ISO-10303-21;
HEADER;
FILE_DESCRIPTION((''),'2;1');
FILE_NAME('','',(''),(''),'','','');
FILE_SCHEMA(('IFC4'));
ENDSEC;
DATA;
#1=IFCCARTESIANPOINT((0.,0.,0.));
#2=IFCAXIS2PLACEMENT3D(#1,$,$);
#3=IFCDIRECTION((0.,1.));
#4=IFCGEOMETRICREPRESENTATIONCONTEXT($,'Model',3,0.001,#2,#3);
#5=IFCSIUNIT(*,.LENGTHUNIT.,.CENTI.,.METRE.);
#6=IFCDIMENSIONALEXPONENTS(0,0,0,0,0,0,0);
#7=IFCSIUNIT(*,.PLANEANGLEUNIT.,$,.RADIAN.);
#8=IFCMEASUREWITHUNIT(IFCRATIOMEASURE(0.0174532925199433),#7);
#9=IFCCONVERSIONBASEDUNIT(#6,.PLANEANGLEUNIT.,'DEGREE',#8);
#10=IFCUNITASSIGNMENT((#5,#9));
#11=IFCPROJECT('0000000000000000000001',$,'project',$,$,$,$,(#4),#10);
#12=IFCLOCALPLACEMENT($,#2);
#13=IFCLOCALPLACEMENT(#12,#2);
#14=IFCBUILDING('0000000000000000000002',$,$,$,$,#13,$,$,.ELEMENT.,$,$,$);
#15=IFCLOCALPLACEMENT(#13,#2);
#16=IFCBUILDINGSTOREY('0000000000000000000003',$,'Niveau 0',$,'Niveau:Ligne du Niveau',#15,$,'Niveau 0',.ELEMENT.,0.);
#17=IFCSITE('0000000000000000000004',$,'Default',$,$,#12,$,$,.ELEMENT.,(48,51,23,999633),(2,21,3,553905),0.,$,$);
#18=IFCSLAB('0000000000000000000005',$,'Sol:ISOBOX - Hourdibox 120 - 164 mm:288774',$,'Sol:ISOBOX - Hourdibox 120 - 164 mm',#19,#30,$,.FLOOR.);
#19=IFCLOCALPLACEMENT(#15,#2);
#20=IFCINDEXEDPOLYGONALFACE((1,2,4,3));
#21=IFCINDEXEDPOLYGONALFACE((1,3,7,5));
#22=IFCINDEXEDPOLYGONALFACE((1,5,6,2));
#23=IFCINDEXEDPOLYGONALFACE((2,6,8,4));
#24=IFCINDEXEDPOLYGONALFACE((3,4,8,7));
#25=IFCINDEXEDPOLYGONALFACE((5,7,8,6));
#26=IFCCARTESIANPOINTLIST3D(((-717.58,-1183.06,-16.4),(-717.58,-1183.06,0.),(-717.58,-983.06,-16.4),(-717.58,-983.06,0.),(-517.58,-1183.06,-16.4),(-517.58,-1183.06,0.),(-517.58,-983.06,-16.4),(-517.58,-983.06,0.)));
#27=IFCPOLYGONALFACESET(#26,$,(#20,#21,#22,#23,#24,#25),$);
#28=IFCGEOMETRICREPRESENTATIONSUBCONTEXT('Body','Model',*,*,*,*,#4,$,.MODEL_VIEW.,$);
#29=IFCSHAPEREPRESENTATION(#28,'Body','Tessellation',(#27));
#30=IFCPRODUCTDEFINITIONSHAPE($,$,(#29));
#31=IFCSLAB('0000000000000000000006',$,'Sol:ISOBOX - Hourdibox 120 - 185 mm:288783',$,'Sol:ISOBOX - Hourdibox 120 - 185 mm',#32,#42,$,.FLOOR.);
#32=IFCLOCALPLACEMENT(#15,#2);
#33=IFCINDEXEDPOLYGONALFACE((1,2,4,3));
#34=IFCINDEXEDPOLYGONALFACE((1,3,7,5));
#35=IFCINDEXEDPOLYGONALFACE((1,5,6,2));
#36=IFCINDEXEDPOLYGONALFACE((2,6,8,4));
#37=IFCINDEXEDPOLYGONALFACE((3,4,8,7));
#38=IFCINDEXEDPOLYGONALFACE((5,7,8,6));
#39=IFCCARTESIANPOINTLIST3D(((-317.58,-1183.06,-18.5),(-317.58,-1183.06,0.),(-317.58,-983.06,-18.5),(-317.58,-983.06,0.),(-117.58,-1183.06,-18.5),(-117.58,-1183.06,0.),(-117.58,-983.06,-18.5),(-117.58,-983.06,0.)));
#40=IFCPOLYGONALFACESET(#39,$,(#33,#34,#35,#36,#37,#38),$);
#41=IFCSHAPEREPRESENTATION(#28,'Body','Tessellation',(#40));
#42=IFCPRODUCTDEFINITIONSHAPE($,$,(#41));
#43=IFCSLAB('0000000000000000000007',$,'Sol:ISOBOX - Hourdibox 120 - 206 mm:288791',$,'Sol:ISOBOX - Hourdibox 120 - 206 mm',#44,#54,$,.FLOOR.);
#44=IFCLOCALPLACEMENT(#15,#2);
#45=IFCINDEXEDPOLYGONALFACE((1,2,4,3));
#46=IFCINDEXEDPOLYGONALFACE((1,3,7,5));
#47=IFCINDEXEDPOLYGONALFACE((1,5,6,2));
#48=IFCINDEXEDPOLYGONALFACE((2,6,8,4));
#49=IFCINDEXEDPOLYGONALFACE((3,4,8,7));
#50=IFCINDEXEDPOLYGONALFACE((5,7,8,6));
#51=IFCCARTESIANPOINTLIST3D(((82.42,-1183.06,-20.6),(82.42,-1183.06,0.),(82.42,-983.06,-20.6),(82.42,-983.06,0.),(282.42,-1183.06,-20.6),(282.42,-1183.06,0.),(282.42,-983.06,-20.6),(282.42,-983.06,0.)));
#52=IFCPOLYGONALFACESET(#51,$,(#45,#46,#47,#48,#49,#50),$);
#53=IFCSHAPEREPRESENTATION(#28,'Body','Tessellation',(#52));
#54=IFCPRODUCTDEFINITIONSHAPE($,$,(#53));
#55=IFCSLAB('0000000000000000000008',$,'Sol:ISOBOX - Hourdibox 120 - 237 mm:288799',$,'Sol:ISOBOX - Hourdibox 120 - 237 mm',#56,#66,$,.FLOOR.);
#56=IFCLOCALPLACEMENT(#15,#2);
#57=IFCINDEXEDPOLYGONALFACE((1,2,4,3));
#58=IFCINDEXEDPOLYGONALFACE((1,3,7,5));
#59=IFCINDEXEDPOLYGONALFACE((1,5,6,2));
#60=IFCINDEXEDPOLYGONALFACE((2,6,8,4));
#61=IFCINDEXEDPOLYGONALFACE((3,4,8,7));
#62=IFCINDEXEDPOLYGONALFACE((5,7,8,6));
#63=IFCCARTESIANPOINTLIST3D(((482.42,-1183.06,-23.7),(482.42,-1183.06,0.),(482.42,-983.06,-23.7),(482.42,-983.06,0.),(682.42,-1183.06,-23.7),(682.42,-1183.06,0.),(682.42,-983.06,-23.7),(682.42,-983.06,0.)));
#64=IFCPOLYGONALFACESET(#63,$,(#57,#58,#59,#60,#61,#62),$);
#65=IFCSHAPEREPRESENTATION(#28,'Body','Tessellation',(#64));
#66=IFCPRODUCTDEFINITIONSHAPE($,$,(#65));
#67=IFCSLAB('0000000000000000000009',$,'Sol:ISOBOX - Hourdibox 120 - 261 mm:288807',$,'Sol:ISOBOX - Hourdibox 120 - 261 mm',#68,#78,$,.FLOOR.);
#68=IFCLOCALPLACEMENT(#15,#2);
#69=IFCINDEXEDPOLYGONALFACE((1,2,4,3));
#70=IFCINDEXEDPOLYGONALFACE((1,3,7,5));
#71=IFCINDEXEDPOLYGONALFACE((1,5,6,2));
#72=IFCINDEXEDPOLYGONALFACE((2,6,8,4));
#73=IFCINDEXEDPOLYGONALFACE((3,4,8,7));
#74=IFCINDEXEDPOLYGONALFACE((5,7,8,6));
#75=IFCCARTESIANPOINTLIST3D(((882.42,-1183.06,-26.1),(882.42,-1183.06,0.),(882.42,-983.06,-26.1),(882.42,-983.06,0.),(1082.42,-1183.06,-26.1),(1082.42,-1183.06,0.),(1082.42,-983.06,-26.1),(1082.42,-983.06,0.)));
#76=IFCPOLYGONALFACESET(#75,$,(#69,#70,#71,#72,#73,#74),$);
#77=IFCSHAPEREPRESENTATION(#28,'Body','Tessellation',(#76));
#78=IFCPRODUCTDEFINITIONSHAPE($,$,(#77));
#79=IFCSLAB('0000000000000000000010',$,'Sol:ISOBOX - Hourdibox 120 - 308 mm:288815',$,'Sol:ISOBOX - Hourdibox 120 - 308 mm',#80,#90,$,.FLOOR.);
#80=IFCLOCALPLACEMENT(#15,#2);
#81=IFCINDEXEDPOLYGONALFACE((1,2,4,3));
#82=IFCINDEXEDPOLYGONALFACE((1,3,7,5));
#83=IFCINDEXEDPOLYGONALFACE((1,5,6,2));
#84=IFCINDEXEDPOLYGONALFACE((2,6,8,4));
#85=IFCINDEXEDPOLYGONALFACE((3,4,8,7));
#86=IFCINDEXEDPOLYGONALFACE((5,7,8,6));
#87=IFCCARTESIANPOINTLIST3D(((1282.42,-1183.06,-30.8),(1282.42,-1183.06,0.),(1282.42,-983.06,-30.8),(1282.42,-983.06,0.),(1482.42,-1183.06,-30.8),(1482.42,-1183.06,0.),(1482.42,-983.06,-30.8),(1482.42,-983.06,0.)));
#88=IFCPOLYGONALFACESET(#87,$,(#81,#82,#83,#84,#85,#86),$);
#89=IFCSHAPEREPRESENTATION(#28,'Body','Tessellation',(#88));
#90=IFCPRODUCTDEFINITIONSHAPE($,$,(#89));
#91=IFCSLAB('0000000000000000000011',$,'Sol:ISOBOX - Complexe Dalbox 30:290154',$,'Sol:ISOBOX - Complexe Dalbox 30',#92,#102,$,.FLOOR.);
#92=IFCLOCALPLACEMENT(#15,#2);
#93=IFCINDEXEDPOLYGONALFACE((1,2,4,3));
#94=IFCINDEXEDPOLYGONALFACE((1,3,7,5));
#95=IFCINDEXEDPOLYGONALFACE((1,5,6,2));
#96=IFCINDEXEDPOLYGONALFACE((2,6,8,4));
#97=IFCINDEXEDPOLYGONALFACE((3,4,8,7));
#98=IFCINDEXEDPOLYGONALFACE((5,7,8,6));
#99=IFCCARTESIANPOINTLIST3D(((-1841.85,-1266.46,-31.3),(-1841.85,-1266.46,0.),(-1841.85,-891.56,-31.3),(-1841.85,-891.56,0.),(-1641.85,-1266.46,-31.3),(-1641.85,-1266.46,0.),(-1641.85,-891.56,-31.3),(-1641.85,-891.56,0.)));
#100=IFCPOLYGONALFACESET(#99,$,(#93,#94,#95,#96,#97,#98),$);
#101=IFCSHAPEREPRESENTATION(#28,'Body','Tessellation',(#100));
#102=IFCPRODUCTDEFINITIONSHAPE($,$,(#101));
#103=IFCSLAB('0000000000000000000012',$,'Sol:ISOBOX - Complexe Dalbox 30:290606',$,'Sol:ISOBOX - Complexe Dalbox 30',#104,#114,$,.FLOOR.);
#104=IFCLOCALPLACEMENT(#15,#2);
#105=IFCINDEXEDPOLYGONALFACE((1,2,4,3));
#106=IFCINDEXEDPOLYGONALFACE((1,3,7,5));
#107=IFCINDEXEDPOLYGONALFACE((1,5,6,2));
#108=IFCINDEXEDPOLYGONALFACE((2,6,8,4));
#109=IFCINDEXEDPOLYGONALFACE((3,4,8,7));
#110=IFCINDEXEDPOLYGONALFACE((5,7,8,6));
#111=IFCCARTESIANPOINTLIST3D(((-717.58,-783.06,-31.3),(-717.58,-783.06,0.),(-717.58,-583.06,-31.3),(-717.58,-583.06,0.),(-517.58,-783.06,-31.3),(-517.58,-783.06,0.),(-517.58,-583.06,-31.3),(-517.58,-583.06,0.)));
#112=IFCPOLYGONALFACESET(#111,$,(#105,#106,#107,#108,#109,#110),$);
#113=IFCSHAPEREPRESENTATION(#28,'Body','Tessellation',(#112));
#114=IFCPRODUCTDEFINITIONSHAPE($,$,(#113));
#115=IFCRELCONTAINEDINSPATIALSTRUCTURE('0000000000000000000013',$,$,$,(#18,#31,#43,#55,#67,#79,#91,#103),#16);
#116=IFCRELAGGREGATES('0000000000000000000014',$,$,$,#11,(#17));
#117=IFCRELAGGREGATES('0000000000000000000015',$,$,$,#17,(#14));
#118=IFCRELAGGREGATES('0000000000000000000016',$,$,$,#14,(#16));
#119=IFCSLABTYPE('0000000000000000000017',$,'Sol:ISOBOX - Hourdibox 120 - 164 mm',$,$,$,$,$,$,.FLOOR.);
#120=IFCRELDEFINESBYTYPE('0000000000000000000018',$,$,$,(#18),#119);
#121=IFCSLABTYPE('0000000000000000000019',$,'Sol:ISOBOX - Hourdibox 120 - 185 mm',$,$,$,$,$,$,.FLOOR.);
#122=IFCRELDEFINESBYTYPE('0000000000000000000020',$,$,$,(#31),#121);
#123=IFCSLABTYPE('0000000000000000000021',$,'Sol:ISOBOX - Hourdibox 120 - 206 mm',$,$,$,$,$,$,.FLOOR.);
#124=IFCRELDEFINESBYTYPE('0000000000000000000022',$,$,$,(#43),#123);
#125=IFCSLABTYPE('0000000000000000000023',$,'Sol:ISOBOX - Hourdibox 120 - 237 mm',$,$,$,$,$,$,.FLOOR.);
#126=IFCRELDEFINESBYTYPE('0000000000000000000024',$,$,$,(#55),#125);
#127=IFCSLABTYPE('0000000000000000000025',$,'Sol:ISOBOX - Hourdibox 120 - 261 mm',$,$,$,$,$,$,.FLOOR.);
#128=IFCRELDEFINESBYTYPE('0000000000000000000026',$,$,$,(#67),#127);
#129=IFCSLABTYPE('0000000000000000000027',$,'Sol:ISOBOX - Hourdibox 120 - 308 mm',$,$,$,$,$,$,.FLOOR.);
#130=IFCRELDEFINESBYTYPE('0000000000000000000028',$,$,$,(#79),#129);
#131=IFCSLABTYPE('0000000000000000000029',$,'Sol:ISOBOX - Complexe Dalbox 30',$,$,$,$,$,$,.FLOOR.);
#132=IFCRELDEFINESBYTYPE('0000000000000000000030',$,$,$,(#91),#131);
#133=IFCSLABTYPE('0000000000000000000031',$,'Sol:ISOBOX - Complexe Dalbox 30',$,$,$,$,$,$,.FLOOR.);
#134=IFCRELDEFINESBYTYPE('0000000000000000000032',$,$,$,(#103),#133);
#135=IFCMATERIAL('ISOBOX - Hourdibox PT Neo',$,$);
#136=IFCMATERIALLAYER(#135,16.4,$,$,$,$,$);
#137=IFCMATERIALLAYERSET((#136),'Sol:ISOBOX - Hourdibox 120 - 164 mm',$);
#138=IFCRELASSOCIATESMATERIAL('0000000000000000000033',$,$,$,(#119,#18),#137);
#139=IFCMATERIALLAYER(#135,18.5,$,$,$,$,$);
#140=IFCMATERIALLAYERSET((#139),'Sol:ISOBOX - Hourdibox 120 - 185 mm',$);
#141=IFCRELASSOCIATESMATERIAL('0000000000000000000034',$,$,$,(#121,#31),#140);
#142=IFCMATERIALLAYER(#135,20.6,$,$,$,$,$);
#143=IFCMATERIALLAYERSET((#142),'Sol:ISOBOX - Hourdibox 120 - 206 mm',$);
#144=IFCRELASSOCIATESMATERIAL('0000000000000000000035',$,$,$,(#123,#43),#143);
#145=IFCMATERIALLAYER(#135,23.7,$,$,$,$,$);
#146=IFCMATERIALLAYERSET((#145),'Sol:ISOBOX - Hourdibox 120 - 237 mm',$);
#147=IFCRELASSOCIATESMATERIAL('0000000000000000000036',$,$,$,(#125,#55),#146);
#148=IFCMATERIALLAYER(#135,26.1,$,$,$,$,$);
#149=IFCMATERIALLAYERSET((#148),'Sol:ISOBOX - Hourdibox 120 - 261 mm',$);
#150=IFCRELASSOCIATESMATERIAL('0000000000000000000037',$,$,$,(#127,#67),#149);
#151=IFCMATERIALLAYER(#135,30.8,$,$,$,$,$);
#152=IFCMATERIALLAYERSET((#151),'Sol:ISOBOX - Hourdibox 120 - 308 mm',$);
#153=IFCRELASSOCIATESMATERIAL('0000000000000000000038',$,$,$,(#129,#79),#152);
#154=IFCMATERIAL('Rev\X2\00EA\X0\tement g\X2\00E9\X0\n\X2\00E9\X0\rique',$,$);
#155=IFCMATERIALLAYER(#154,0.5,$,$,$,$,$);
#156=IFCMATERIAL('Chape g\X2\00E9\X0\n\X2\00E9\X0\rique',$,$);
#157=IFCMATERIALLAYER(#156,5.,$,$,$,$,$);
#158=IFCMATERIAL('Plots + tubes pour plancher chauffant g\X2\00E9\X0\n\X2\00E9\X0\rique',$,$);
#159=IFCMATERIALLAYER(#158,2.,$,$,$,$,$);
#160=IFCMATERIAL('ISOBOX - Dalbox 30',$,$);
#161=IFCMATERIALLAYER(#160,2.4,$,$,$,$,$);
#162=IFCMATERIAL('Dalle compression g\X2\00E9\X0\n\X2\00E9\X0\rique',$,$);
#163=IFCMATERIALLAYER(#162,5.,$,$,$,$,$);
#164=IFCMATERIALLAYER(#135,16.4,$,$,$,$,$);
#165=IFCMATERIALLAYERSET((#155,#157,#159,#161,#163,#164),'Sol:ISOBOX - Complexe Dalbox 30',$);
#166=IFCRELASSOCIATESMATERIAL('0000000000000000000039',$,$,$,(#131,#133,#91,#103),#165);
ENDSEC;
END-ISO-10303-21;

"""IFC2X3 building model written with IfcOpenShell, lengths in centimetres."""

from ifc_helpers import new_model, entity, si_unit, converted_unit, direction, frame, frame_2d, origin, origin_2d_with_axis, place, context, subcontext, project, spatial, rectangle, extrude, material, layer, layer_set, layer_usage, type_object, element, save


model = new_model("IFC2X3")

# Units and contexts
model_context = context("Model", 3, precision=0.001, world=origin(), true_north=direction((0.0, 1.0)))
body_context = subcontext(model_context, "Body", "Model", "MODEL_VIEW")
ifc_project = project(units=[si_unit("LENGTHUNIT", "METRE", prefix="CENTI"), converted_unit("PLANEANGLEUNIT", "DEGREE", entity("IfcRatioMeasure", 0.0174532925199433), si_unit("PLANEANGLEUNIT", "RADIAN"), dimensions=[0, 0, 0, 0, 0, 0, 0])], contexts=[model_context])

# Site, building, storey
site_placement = place(None, origin())
site = spatial("IfcSite", under=ifc_project, at=site_placement, Name="Default", CompositionType="ELEMENT", RefLatitude=(48, 51, 23, 999633), RefLongitude=(2, 21, 3, 553905), RefElevation=0.0)
building_placement = place(site_placement, origin())
building = spatial("IfcBuilding", under=site, at=building_placement, CompositionType="ELEMENT")
storey_placement = place(building_placement, origin())
storey = spatial("IfcBuildingStorey", under=building, at=storey_placement, Name="Niveau 0", ObjectType="Niveau:Ligne du Niveau", LongName="Niveau 0", CompositionType="ELEMENT", Elevation=0.0)

# Slabs
ifc_material_1 = material(Name="ISOBOX - Hourdibox PT Neo")
ifc_layer_1 = layer(ifc_material_1, 16.4)
ifc_layer_set_1 = layer_set([ifc_layer_1], Name="Sol:ISOBOX - Hourdibox 120 - 164 mm")
ifc_layer_usage_1 = layer_usage(ifc_layer_set_1, "AXIS3", "POSITIVE", 0.0)
slab_type_1 = type_object("IfcSlabType", Name="Sol:ISOBOX - Hourdibox 120 - 164 mm", PredefinedType="FLOOR", material=ifc_layer_set_1)
slab_1_placement = place(storey_placement, origin())
element("IfcSlab", 1, at=slab_1_placement, inside=storey, type_object=slab_type_1, material=ifc_layer_usage_1, Name="Sol:ISOBOX - Hourdibox 120 - 164 mm:288774", ObjectType="Sol:ISOBOX - Hourdibox 120 - 164 mm", PredefinedType="FLOOR", context=body_context, shape_type="SweptSolid", body=[
    extrude(rectangle(XDim=200.0, YDim=200.0, at=origin_2d_with_axis()), frame((-617.58, -1083.06, 0.0), z_axis=(0.0, 0.0, -1.0), x_axis=(0.0, 1.0, 0.0)), (0.0, 0.0, 1.0), 16.4),
])
ifc_layer_2 = layer(ifc_material_1, 18.5)
ifc_layer_set_2 = layer_set([ifc_layer_2], Name="Sol:ISOBOX - Hourdibox 120 - 185 mm")
ifc_layer_usage_2 = layer_usage(ifc_layer_set_2, "AXIS3", "POSITIVE", 0.0)
slab_type_2 = type_object("IfcSlabType", Name="Sol:ISOBOX - Hourdibox 120 - 185 mm", PredefinedType="FLOOR", material=ifc_layer_set_2)
slab_2_placement = place(storey_placement, origin())
element("IfcSlab", 2, at=slab_2_placement, inside=storey, type_object=slab_type_2, material=ifc_layer_usage_2, Name="Sol:ISOBOX - Hourdibox 120 - 185 mm:288783", ObjectType="Sol:ISOBOX - Hourdibox 120 - 185 mm", PredefinedType="FLOOR", context=body_context, shape_type="SweptSolid", body=[
    extrude(rectangle(XDim=200.0, YDim=200.0, at=origin_2d_with_axis()), frame((-217.58, -1083.06, 0.0), z_axis=(0.0, 0.0, -1.0), x_axis=(0.0, 1.0, 0.0)), (0.0, 0.0, 1.0), 18.5),
])
ifc_layer_3 = layer(ifc_material_1, 20.6)
ifc_layer_set_3 = layer_set([ifc_layer_3], Name="Sol:ISOBOX - Hourdibox 120 - 206 mm")
ifc_layer_usage_3 = layer_usage(ifc_layer_set_3, "AXIS3", "POSITIVE", 0.0)
slab_type_3 = type_object("IfcSlabType", Name="Sol:ISOBOX - Hourdibox 120 - 206 mm", PredefinedType="FLOOR", material=ifc_layer_set_3)
slab_3_placement = place(storey_placement, origin())
element("IfcSlab", 3, at=slab_3_placement, inside=storey, type_object=slab_type_3, material=ifc_layer_usage_3, Name="Sol:ISOBOX - Hourdibox 120 - 206 mm:288791", ObjectType="Sol:ISOBOX - Hourdibox 120 - 206 mm", PredefinedType="FLOOR", context=body_context, shape_type="SweptSolid", body=[
    extrude(rectangle(XDim=200.0, YDim=200.0, at=origin_2d_with_axis()), frame((182.42, -1083.06, 0.0), z_axis=(0.0, 0.0, -1.0), x_axis=(0.0, 1.0, 0.0)), (0.0, 0.0, 1.0), 20.6),
])
ifc_layer_4 = layer(ifc_material_1, 23.7)
ifc_layer_set_4 = layer_set([ifc_layer_4], Name="Sol:ISOBOX - Hourdibox 120 - 237 mm")
ifc_layer_usage_4 = layer_usage(ifc_layer_set_4, "AXIS3", "POSITIVE", 0.0)
slab_type_4 = type_object("IfcSlabType", Name="Sol:ISOBOX - Hourdibox 120 - 237 mm", PredefinedType="FLOOR", material=ifc_layer_set_4)
slab_4_placement = place(storey_placement, origin())
element("IfcSlab", 4, at=slab_4_placement, inside=storey, type_object=slab_type_4, material=ifc_layer_usage_4, Name="Sol:ISOBOX - Hourdibox 120 - 237 mm:288799", ObjectType="Sol:ISOBOX - Hourdibox 120 - 237 mm", PredefinedType="FLOOR", context=body_context, shape_type="SweptSolid", body=[
    extrude(rectangle(XDim=200.0, YDim=200.0, at=frame_2d((0.0, 0.0), x_axis=(1.0, 0.0))), frame((582.42, -1083.06, 0.0), z_axis=(0.0, 0.0, -1.0), x_axis=(0.0, 1.0, 0.0)), (0.0, 0.0, 1.0), 23.7),
])
ifc_layer_5 = layer(ifc_material_1, 26.1)
ifc_layer_set_5 = layer_set([ifc_layer_5], Name="Sol:ISOBOX - Hourdibox 120 - 261 mm")
ifc_layer_usage_5 = layer_usage(ifc_layer_set_5, "AXIS3", "POSITIVE", 0.0)
slab_type_5 = type_object("IfcSlabType", Name="Sol:ISOBOX - Hourdibox 120 - 261 mm", PredefinedType="FLOOR", material=ifc_layer_set_5)
slab_5_placement = place(storey_placement, origin())
element("IfcSlab", 5, at=slab_5_placement, inside=storey, type_object=slab_type_5, material=ifc_layer_usage_5, Name="Sol:ISOBOX - Hourdibox 120 - 261 mm:288807", ObjectType="Sol:ISOBOX - Hourdibox 120 - 261 mm", PredefinedType="FLOOR", context=body_context, shape_type="SweptSolid", body=[
    extrude(rectangle(XDim=200.0, YDim=200.0, at=origin_2d_with_axis()), frame((982.42, -1083.06, 0.0), z_axis=(0.0, 0.0, -1.0), x_axis=(0.0, 1.0, 0.0)), (0.0, 0.0, 1.0), 26.1),
])
ifc_layer_6 = layer(ifc_material_1, 30.8)
ifc_layer_set_6 = layer_set([ifc_layer_6], Name="Sol:ISOBOX - Hourdibox 120 - 308 mm")
ifc_layer_usage_6 = layer_usage(ifc_layer_set_6, "AXIS3", "POSITIVE", 0.0)
slab_type_6 = type_object("IfcSlabType", Name="Sol:ISOBOX - Hourdibox 120 - 308 mm", PredefinedType="FLOOR", material=ifc_layer_set_6)
slab_6_placement = place(storey_placement, origin())
element("IfcSlab", 6, at=slab_6_placement, inside=storey, type_object=slab_type_6, material=ifc_layer_usage_6, Name="Sol:ISOBOX - Hourdibox 120 - 308 mm:288815", ObjectType="Sol:ISOBOX - Hourdibox 120 - 308 mm", PredefinedType="FLOOR", context=body_context, shape_type="SweptSolid", body=[
    extrude(rectangle(XDim=200.0, YDim=200.0, at=origin_2d_with_axis()), frame((1382.42, -1083.06, 0.0), z_axis=(0.0, 0.0, -1.0), x_axis=(0.0, 1.0, 0.0)), (0.0, 0.0, 1.0), 30.8),
])
ifc_material_2 = material(Name="Revêtement générique")
ifc_layer_7 = layer(ifc_material_2, 0.5)
ifc_material_3 = material(Name="Chape générique")
ifc_layer_8 = layer(ifc_material_3, 5.0)
ifc_material_4 = material(Name="Plots + tubes pour plancher chauffant générique")
ifc_layer_9 = layer(ifc_material_4, 2.0)
ifc_material_5 = material(Name="ISOBOX - Dalbox 30")
ifc_layer_10 = layer(ifc_material_5, 2.4)
ifc_material_6 = material(Name="Dalle compression générique")
ifc_layer_11 = layer(ifc_material_6, 5.0)
ifc_layer_12 = layer(ifc_material_1, 16.4)
ifc_layer_set_7 = layer_set([ifc_layer_7, ifc_layer_8, ifc_layer_9, ifc_layer_10, ifc_layer_11, ifc_layer_12], Name="Sol:ISOBOX - Complexe Dalbox 30")
ifc_layer_usage_7 = layer_usage(ifc_layer_set_7, "AXIS3", "POSITIVE", 0.0)
slab_type_7 = type_object("IfcSlabType", Name="Sol:ISOBOX - Complexe Dalbox 30", PredefinedType="FLOOR", material=ifc_layer_set_7)
slab_7_placement = place(storey_placement, origin())
element("IfcSlab", 7, at=slab_7_placement, inside=storey, type_object=slab_type_7, material=ifc_layer_usage_7, Name="Sol:ISOBOX - Complexe Dalbox 30:290154", ObjectType="Sol:ISOBOX - Complexe Dalbox 30", PredefinedType="FLOOR", context=body_context, shape_type="SweptSolid", body=[
    extrude(rectangle(XDim=374.9, YDim=200.0, at=frame_2d((0.0, 0.0), x_axis=(1.0, 0.0))), frame((-1741.85, -1079.01, 0.0), z_axis=(0.0, 0.0, -1.0), x_axis=(0.0, 1.0, 0.0)), (0.0, 0.0, 1.0), 31.3),
])
ifc_layer_usage_8 = layer_usage(ifc_layer_set_7, "AXIS3", "POSITIVE", 0.0)
slab_type_8 = type_object("IfcSlabType", Name="Sol:ISOBOX - Complexe Dalbox 30", PredefinedType="FLOOR", material=ifc_layer_set_7)
slab_8_placement = place(storey_placement, origin())
element("IfcSlab", 8, at=slab_8_placement, inside=storey, type_object=slab_type_8, material=ifc_layer_usage_8, Name="Sol:ISOBOX - Complexe Dalbox 30:290606", ObjectType="Sol:ISOBOX - Complexe Dalbox 30", PredefinedType="FLOOR", context=body_context, shape_type="SweptSolid", body=[
    extrude(rectangle(XDim=200.0, YDim=200.0, at=origin_2d_with_axis()), frame((-617.58, -683.06, 0.0), z_axis=(0.0, 0.0, -1.0), x_axis=(0.0, 1.0, 0.0)), (0.0, 0.0, 1.0), 31.3),
])

save(model, "model.ifc")
